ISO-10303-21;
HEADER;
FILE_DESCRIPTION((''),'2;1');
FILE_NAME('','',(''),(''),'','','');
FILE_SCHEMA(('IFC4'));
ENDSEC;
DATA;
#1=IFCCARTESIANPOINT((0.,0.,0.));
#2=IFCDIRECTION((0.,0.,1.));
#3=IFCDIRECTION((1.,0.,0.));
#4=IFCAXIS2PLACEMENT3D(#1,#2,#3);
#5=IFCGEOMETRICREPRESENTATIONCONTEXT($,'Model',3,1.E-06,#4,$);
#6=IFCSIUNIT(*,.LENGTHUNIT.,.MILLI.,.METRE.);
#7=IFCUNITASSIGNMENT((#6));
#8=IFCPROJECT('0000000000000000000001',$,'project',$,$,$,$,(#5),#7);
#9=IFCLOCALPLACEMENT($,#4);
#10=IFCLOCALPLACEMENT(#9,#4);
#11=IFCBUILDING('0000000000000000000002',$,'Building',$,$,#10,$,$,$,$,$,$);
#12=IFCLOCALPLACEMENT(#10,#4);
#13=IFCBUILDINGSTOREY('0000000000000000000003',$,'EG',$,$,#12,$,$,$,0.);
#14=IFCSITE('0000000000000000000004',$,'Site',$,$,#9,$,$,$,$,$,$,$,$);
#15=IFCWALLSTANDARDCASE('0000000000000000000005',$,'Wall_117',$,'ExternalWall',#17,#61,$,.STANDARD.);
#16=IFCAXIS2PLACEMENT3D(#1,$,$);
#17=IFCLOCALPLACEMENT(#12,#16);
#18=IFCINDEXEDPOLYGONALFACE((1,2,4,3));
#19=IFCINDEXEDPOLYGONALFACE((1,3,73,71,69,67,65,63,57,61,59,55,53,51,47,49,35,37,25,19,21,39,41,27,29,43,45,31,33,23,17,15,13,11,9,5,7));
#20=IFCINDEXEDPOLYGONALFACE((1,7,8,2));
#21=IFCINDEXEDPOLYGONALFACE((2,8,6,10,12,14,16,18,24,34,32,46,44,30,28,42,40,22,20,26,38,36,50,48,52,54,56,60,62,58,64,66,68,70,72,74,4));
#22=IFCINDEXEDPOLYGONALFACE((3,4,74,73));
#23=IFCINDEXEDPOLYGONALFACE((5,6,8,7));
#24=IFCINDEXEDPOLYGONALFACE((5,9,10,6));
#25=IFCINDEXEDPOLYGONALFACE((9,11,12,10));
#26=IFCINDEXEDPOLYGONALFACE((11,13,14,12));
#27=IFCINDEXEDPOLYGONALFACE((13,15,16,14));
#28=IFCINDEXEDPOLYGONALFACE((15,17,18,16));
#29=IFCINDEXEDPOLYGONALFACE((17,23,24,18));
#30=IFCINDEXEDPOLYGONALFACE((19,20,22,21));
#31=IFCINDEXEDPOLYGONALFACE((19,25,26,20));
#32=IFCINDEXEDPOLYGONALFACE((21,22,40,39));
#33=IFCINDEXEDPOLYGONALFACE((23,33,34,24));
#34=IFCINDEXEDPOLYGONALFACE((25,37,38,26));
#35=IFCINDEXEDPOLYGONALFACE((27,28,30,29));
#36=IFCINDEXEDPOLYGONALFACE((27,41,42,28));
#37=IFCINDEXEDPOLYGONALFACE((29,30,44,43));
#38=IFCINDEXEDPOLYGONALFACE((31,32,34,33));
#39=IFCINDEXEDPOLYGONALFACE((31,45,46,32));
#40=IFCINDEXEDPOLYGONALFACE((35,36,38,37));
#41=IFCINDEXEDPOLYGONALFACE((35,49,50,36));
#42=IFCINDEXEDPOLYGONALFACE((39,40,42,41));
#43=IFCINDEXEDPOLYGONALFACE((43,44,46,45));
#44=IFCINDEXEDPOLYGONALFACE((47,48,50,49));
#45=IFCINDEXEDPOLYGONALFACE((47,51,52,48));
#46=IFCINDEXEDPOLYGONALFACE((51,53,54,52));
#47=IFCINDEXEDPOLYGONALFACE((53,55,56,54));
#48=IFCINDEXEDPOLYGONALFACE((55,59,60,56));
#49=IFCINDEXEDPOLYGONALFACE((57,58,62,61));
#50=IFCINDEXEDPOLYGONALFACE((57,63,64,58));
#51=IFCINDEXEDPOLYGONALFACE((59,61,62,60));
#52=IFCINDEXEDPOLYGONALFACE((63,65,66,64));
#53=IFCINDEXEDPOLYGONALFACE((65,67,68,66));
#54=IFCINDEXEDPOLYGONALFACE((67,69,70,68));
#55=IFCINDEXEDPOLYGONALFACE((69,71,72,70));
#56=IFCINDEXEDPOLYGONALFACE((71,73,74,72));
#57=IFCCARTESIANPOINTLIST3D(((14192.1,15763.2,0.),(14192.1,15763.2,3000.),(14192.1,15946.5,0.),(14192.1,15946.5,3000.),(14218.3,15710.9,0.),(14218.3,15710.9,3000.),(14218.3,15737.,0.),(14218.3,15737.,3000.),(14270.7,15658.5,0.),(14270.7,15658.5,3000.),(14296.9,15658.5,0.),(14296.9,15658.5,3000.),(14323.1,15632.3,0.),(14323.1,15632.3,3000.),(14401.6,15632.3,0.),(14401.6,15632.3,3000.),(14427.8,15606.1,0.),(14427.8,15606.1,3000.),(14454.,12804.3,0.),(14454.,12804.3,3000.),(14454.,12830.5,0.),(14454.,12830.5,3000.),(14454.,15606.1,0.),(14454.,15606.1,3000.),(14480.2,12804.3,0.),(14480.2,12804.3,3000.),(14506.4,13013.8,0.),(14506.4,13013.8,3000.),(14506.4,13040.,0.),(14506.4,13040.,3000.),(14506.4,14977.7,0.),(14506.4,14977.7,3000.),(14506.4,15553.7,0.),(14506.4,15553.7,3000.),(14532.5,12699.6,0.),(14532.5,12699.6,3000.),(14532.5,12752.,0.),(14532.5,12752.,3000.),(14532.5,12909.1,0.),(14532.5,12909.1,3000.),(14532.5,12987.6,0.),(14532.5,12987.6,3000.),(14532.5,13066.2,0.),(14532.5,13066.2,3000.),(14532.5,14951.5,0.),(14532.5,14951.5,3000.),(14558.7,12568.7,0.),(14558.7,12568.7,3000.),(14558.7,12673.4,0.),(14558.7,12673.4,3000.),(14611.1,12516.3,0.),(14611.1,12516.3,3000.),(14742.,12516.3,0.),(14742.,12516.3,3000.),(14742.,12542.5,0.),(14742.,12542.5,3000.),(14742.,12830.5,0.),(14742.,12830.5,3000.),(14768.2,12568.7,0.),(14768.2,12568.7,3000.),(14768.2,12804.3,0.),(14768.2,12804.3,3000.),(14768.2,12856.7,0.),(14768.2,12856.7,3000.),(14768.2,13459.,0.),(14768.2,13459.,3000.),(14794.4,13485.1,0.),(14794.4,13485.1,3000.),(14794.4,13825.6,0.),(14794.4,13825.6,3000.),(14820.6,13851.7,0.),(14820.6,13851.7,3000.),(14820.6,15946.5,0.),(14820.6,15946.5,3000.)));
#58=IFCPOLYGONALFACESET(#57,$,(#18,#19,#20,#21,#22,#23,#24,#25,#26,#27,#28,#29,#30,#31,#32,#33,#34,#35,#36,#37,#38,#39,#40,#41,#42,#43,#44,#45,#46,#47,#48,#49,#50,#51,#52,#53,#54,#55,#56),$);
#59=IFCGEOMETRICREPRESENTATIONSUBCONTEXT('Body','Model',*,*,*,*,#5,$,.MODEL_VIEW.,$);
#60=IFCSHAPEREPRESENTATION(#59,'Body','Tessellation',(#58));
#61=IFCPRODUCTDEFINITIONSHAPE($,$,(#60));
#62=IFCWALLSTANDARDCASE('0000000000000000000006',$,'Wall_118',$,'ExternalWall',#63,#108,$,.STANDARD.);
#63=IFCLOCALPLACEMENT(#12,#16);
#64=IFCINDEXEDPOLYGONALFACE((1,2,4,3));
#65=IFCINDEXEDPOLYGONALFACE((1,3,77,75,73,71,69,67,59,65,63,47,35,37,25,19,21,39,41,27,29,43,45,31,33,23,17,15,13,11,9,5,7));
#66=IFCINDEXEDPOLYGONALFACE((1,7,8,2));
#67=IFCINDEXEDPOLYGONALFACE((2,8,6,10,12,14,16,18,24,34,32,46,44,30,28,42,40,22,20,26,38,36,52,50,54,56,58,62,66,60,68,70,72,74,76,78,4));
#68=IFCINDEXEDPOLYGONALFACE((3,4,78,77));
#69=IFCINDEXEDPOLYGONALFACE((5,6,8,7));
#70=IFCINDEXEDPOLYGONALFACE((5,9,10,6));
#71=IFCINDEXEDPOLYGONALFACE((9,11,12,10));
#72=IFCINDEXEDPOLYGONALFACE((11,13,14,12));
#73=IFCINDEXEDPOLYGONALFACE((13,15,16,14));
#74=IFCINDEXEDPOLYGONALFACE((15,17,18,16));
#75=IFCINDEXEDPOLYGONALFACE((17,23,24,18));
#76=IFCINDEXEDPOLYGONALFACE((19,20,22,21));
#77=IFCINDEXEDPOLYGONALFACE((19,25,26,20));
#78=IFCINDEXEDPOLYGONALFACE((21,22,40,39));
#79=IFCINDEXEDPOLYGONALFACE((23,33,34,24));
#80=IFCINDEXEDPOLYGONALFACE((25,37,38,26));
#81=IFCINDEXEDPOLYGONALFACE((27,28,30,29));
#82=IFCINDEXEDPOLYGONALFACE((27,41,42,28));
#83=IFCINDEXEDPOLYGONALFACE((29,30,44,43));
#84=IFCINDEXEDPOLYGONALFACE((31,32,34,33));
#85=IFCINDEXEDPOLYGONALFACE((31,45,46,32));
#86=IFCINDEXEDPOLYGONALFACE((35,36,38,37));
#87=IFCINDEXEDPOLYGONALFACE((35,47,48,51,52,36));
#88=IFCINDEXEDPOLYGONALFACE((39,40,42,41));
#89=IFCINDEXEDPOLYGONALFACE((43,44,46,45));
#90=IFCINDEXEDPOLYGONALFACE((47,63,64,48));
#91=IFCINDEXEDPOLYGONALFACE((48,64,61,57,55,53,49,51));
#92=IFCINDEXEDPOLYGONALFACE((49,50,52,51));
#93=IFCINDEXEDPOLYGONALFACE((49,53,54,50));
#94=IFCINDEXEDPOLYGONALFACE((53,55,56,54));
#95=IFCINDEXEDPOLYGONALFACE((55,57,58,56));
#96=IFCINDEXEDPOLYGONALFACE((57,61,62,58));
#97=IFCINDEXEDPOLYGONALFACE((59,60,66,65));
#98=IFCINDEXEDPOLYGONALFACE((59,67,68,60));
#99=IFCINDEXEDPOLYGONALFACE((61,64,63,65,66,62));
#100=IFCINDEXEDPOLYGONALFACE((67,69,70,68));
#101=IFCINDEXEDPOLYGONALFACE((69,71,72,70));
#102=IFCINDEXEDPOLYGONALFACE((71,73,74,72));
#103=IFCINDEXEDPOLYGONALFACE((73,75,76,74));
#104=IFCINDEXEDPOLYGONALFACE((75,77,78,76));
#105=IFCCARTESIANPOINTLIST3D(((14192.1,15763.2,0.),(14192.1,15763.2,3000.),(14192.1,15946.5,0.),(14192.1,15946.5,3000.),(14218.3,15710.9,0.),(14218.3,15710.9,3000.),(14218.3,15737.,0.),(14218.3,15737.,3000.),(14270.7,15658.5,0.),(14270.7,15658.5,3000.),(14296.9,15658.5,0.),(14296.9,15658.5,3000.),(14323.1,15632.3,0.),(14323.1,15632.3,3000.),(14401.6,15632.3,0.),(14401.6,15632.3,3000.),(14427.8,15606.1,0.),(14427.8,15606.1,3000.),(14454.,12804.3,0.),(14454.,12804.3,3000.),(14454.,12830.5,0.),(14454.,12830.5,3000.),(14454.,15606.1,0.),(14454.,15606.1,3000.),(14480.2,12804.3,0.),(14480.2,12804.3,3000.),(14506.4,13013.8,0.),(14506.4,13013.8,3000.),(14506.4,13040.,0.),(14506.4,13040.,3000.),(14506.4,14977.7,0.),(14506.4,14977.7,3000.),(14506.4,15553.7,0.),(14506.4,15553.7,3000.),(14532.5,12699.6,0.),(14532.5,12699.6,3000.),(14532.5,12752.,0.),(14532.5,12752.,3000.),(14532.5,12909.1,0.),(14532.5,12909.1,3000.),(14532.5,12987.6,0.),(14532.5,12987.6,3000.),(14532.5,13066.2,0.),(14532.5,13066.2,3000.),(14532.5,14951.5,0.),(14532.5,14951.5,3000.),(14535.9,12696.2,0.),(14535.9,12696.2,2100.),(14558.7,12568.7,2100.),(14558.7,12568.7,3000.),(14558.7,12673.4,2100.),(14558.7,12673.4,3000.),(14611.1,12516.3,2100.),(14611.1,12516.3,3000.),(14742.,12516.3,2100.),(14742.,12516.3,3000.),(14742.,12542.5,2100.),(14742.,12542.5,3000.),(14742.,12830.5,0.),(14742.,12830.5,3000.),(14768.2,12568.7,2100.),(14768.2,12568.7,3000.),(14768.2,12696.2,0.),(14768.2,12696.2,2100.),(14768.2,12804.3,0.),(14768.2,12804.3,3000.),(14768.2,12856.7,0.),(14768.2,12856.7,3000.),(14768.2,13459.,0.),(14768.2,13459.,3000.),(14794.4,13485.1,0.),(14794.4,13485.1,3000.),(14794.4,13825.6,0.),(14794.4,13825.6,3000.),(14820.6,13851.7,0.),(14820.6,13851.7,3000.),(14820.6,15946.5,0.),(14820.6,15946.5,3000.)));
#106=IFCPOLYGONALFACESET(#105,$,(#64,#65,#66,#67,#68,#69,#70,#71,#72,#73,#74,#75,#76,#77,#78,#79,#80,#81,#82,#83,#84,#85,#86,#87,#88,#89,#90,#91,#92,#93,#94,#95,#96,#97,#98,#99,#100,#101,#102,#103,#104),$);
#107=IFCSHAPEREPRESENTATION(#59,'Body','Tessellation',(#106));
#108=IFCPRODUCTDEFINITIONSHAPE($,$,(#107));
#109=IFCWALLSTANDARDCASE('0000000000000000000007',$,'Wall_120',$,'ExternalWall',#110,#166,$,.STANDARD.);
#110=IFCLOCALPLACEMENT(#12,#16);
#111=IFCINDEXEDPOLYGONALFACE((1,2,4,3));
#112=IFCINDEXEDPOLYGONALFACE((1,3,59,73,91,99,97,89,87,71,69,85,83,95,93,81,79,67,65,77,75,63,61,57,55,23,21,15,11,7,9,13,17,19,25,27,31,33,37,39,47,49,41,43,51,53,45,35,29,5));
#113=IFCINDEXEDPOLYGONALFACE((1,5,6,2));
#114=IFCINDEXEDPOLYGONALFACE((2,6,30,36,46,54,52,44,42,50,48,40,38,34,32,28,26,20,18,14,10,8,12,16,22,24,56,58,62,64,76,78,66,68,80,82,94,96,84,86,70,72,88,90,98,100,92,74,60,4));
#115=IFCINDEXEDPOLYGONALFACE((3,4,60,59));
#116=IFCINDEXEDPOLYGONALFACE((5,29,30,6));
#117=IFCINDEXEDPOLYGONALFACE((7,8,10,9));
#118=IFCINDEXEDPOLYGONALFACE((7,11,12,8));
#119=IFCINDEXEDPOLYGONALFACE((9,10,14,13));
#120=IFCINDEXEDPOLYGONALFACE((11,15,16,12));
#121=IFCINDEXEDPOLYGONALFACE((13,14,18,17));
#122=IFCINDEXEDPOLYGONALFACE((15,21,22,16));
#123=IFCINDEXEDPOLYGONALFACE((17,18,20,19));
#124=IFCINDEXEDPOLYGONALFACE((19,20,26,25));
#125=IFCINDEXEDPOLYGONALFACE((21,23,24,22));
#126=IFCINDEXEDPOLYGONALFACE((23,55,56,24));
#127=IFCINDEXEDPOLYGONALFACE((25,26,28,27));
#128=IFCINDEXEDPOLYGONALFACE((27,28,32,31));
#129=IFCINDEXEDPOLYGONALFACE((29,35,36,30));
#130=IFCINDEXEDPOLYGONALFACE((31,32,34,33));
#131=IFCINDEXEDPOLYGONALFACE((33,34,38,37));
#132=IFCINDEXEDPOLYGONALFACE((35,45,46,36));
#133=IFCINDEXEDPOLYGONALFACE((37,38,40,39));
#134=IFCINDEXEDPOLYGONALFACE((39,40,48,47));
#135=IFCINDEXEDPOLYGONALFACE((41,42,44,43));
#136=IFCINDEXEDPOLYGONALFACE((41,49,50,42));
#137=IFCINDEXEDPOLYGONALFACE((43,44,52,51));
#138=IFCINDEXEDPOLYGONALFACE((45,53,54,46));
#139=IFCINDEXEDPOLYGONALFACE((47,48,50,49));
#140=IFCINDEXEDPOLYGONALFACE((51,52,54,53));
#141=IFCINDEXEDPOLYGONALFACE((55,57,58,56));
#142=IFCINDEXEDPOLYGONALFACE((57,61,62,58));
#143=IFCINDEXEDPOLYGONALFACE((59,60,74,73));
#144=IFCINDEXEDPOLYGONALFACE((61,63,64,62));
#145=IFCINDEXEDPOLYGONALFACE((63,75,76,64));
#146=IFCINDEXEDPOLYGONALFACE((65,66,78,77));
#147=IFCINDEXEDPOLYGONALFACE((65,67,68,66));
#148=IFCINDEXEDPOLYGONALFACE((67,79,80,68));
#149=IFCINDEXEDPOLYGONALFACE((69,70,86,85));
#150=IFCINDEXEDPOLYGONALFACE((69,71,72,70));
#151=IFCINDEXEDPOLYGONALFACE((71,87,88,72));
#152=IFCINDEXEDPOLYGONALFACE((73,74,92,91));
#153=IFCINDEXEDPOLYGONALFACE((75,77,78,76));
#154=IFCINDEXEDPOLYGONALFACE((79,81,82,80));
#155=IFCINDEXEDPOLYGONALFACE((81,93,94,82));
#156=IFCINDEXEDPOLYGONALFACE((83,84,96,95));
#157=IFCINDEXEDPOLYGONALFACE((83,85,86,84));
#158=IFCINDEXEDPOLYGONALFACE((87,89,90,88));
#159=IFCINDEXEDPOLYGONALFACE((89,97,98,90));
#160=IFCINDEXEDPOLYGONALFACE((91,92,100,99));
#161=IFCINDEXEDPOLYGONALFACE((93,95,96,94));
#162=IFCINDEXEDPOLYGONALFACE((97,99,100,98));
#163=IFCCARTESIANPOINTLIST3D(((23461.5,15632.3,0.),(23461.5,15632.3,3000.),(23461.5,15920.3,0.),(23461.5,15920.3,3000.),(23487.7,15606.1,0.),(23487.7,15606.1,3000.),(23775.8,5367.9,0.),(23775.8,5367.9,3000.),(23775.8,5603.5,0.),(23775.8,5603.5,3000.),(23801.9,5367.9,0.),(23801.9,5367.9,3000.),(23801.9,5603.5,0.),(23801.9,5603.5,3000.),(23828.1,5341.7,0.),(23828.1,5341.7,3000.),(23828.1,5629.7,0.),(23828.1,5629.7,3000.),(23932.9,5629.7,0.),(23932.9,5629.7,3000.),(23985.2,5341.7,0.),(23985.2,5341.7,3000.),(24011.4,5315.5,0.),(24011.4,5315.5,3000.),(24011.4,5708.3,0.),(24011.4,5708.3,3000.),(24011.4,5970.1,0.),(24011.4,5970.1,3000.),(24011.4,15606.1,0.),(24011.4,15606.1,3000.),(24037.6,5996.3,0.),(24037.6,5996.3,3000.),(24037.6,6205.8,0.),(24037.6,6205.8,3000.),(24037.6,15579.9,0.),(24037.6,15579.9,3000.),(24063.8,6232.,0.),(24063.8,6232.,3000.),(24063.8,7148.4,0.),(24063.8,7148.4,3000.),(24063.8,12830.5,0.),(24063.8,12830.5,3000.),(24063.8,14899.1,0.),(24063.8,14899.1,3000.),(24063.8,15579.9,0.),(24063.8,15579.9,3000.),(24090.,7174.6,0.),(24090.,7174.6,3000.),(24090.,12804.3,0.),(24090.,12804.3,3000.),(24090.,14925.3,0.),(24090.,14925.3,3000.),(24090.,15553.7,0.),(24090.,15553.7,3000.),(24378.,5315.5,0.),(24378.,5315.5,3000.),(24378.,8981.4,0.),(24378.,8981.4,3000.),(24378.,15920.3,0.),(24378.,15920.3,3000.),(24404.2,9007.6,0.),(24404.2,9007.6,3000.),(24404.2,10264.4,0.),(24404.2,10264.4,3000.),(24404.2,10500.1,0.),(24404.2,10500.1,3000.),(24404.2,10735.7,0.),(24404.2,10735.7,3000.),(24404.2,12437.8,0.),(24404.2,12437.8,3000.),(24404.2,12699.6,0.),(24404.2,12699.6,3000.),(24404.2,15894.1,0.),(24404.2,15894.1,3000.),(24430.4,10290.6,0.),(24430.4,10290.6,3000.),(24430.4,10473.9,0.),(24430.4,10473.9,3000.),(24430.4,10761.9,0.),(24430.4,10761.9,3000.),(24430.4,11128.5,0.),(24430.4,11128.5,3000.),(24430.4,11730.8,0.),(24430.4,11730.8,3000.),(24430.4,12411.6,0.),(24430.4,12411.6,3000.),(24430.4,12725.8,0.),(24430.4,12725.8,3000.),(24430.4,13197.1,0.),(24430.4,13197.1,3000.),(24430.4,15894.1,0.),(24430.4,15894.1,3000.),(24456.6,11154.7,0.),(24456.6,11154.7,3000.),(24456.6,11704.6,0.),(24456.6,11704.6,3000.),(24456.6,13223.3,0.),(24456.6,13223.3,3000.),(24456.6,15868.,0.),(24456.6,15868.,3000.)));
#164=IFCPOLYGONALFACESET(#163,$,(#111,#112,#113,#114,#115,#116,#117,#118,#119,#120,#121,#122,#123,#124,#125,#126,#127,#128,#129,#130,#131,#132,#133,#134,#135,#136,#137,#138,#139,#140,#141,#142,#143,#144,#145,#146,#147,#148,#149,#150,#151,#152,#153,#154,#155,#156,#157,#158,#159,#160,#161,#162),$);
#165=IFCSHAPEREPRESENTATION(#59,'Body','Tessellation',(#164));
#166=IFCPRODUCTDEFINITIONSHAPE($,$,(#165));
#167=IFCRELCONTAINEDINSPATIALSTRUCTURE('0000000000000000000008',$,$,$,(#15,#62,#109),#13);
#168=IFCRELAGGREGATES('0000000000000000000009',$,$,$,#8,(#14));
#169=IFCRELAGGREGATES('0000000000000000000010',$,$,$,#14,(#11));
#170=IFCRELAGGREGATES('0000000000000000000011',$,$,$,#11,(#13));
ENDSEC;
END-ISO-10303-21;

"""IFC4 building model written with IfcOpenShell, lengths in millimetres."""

from ifc_helpers import new_model, si_unit, frame, origin_with_axes, place, context, subcontext, project, spatial, polyline, rectangle, outline, extrude, element, save


model = new_model("IFC4")

# Units and contexts
model_context = context("Model", 3, precision=1e-06, world=origin_with_axes())
body_context = subcontext(model_context, "Body", "Model", "MODEL_VIEW")
ifc_project = project(units=[si_unit("LENGTHUNIT", "METRE", prefix="MILLI")], contexts=[model_context])

# Site, building, storey
site_placement = place(None, origin_with_axes())
site = spatial("IfcSite", under=ifc_project, at=site_placement, Name="Site")
building_placement = place(site_placement, origin_with_axes())
building = spatial("IfcBuilding", under=site, at=building_placement, Name="Building")
storey_placement = place(building_placement, origin_with_axes())
storey = spatial("IfcBuildingStorey", under=building, at=storey_placement, Name="EG", Elevation=0.0)

# Wall
wall_1_placement = place(storey_placement, origin_with_axes())
element("IfcWallStandardCase", 1, at=wall_1_placement, inside=storey, Name="Wall_117", ObjectType="ExternalWall", PredefinedType="STANDARD", context=body_context, shape_type="SweptSolid", body=[
    extrude(outline(polyline([(14611.1, 12516.3, 0.0), (14558.7, 12568.7, 0.0), (14558.7, 12673.4, 0.0), (14532.5, 12699.6, 0.0), (14532.5, 12752.0, 0.0), (14480.2, 12804.3, 0.0), (14454.0, 12804.3, 0.0), (14454.0, 12830.5, 0.0), (14532.5, 12909.1, 0.0), (14532.5, 12987.6, 0.0), (14506.4, 13013.8, 0.0), (14506.4, 13040.0, 0.0), (14532.5, 13066.2, 0.0), (14532.5, 14951.5, 0.0), (14506.4, 14977.7, 0.0), (14506.4, 15553.7, 0.0), (14454.0, 15606.1, 0.0), (14427.8, 15606.1, 0.0), (14401.6, 15632.3, 0.0), (14323.1, 15632.3, 0.0), (14296.9, 15658.5, 0.0), (14270.7, 15658.5, 0.0), (14218.3, 15710.9, 0.0), (14218.3, 15737.0, 0.0), (14192.1, 15763.2, 0.0), (14192.1, 15946.5, 0.0), (14820.6, 15946.5, 0.0), (14820.6, 13851.7, 0.0), (14794.4, 13825.6, 0.0), (14794.4, 13485.1, 0.0), (14768.2, 13459.0, 0.0), (14768.2, 12856.7, 0.0), (14742.0, 12830.5, 0.0), (14768.2, 12804.3, 0.0), (14768.2, 12568.7, 0.0), (14742.0, 12542.5, 0.0), (14742.0, 12516.3, 0.0), (14611.1, 12516.3, 0.0)])), origin_with_axes(), (0.0, 0.0, 1.0), 3000.0),
])

# Wall, opening
wall_2_placement = place(storey_placement, origin_with_axes())
wall_2 = element("IfcWallStandardCase", 2, at=wall_2_placement, inside=storey, Name="Wall_118", ObjectType="ExternalWall", PredefinedType="STANDARD", context=body_context, shape_type="SweptSolid", body=[
    extrude(outline(polyline([(14611.1, 12516.3, 0.0), (14558.7, 12568.7, 0.0), (14558.7, 12673.4, 0.0), (14532.5, 12699.6, 0.0), (14532.5, 12752.0, 0.0), (14480.2, 12804.3, 0.0), (14454.0, 12804.3, 0.0), (14454.0, 12830.5, 0.0), (14532.5, 12909.1, 0.0), (14532.5, 12987.6, 0.0), (14506.4, 13013.8, 0.0), (14506.4, 13040.0, 0.0), (14532.5, 13066.2, 0.0), (14532.5, 14951.5, 0.0), (14506.4, 14977.7, 0.0), (14506.4, 15553.7, 0.0), (14454.0, 15606.1, 0.0), (14427.8, 15606.1, 0.0), (14401.6, 15632.3, 0.0), (14323.1, 15632.3, 0.0), (14296.9, 15658.5, 0.0), (14270.7, 15658.5, 0.0), (14218.3, 15710.9, 0.0), (14218.3, 15737.0, 0.0), (14192.1, 15763.2, 0.0), (14192.1, 15946.5, 0.0), (14820.6, 15946.5, 0.0), (14820.6, 13851.7, 0.0), (14794.4, 13825.6, 0.0), (14794.4, 13485.1, 0.0), (14768.2, 13459.0, 0.0), (14768.2, 12856.7, 0.0), (14742.0, 12830.5, 0.0), (14768.2, 12804.3, 0.0), (14768.2, 12568.7, 0.0), (14742.0, 12542.5, 0.0), (14742.0, 12516.3, 0.0), (14611.1, 12516.3, 0.0)])), origin_with_axes(), (0.0, 0.0, 1.0), 3000.0),
])
opening_1_placement = place(wall_2_placement, origin_with_axes())
element("IfcOpeningElement", 3, at=opening_1_placement, inside=storey, cuts=wall_2, context=body_context, shape_type="SweptSolid", body=[
    extrude(rectangle(XDim=1047.4, YDim=240.0), frame((14296.9, 12576.2, 0.0), z_axis=(0.0, 0.0, 1.0), x_axis=(1.0, 0.0, 0.0)), (0.0, 0.0, 1.0), 2100.0),
])

# Wall
wall_3_placement = place(storey_placement, origin_with_axes())
element("IfcWallStandardCase", 4, at=wall_3_placement, inside=storey, Name="Wall_120", ObjectType="ExternalWall", PredefinedType="STANDARD", context=body_context, shape_type="SweptSolid", body=[
    extrude(outline(polyline([(24011.4, 5315.5, 0.0), (23985.2, 5341.7, 0.0), (23828.1, 5341.7, 0.0), (23801.9, 5367.9, 0.0), (23775.8, 5367.9, 0.0), (23775.8, 5603.5, 0.0), (23801.9, 5603.5, 0.0), (23828.1, 5629.7, 0.0), (23932.9, 5629.7, 0.0), (24011.4, 5708.3, 0.0), (24011.4, 5970.1, 0.0), (24037.6, 5996.3, 0.0), (24037.6, 6205.8, 0.0), (24063.8, 6232.0, 0.0), (24063.8, 7148.4, 0.0), (24090.0, 7174.6, 0.0), (24090.0, 12804.3, 0.0), (24063.8, 12830.5, 0.0), (24063.8, 14899.1, 0.0), (24090.0, 14925.3, 0.0), (24090.0, 15553.7, 0.0), (24063.8, 15579.9, 0.0), (24037.6, 15579.9, 0.0), (24011.4, 15606.1, 0.0), (23487.7, 15606.1, 0.0), (23461.5, 15632.3, 0.0), (23461.5, 15920.3, 0.0), (24378.0, 15920.3, 0.0), (24404.2, 15894.1, 0.0), (24430.4, 15894.1, 0.0), (24456.6, 15868.0, 0.0), (24456.6, 13223.3, 0.0), (24430.4, 13197.1, 0.0), (24430.4, 12725.8, 0.0), (24404.2, 12699.6, 0.0), (24404.2, 12437.8, 0.0), (24430.4, 12411.6, 0.0), (24430.4, 11730.8, 0.0), (24456.6, 11704.6, 0.0), (24456.6, 11154.7, 0.0), (24430.4, 11128.5, 0.0), (24430.4, 10761.9, 0.0), (24404.2, 10735.7, 0.0), (24404.2, 10500.1, 0.0), (24430.4, 10473.9, 0.0), (24430.4, 10290.6, 0.0), (24404.2, 10264.4, 0.0), (24404.2, 9007.6, 0.0), (24378.0, 8981.4, 0.0), (24378.0, 5315.5, 0.0), (24011.4, 5315.5, 0.0)])), origin_with_axes(), (0.0, 0.0, 1.0), 3000.0),
])

save(model, "model.ifc")
